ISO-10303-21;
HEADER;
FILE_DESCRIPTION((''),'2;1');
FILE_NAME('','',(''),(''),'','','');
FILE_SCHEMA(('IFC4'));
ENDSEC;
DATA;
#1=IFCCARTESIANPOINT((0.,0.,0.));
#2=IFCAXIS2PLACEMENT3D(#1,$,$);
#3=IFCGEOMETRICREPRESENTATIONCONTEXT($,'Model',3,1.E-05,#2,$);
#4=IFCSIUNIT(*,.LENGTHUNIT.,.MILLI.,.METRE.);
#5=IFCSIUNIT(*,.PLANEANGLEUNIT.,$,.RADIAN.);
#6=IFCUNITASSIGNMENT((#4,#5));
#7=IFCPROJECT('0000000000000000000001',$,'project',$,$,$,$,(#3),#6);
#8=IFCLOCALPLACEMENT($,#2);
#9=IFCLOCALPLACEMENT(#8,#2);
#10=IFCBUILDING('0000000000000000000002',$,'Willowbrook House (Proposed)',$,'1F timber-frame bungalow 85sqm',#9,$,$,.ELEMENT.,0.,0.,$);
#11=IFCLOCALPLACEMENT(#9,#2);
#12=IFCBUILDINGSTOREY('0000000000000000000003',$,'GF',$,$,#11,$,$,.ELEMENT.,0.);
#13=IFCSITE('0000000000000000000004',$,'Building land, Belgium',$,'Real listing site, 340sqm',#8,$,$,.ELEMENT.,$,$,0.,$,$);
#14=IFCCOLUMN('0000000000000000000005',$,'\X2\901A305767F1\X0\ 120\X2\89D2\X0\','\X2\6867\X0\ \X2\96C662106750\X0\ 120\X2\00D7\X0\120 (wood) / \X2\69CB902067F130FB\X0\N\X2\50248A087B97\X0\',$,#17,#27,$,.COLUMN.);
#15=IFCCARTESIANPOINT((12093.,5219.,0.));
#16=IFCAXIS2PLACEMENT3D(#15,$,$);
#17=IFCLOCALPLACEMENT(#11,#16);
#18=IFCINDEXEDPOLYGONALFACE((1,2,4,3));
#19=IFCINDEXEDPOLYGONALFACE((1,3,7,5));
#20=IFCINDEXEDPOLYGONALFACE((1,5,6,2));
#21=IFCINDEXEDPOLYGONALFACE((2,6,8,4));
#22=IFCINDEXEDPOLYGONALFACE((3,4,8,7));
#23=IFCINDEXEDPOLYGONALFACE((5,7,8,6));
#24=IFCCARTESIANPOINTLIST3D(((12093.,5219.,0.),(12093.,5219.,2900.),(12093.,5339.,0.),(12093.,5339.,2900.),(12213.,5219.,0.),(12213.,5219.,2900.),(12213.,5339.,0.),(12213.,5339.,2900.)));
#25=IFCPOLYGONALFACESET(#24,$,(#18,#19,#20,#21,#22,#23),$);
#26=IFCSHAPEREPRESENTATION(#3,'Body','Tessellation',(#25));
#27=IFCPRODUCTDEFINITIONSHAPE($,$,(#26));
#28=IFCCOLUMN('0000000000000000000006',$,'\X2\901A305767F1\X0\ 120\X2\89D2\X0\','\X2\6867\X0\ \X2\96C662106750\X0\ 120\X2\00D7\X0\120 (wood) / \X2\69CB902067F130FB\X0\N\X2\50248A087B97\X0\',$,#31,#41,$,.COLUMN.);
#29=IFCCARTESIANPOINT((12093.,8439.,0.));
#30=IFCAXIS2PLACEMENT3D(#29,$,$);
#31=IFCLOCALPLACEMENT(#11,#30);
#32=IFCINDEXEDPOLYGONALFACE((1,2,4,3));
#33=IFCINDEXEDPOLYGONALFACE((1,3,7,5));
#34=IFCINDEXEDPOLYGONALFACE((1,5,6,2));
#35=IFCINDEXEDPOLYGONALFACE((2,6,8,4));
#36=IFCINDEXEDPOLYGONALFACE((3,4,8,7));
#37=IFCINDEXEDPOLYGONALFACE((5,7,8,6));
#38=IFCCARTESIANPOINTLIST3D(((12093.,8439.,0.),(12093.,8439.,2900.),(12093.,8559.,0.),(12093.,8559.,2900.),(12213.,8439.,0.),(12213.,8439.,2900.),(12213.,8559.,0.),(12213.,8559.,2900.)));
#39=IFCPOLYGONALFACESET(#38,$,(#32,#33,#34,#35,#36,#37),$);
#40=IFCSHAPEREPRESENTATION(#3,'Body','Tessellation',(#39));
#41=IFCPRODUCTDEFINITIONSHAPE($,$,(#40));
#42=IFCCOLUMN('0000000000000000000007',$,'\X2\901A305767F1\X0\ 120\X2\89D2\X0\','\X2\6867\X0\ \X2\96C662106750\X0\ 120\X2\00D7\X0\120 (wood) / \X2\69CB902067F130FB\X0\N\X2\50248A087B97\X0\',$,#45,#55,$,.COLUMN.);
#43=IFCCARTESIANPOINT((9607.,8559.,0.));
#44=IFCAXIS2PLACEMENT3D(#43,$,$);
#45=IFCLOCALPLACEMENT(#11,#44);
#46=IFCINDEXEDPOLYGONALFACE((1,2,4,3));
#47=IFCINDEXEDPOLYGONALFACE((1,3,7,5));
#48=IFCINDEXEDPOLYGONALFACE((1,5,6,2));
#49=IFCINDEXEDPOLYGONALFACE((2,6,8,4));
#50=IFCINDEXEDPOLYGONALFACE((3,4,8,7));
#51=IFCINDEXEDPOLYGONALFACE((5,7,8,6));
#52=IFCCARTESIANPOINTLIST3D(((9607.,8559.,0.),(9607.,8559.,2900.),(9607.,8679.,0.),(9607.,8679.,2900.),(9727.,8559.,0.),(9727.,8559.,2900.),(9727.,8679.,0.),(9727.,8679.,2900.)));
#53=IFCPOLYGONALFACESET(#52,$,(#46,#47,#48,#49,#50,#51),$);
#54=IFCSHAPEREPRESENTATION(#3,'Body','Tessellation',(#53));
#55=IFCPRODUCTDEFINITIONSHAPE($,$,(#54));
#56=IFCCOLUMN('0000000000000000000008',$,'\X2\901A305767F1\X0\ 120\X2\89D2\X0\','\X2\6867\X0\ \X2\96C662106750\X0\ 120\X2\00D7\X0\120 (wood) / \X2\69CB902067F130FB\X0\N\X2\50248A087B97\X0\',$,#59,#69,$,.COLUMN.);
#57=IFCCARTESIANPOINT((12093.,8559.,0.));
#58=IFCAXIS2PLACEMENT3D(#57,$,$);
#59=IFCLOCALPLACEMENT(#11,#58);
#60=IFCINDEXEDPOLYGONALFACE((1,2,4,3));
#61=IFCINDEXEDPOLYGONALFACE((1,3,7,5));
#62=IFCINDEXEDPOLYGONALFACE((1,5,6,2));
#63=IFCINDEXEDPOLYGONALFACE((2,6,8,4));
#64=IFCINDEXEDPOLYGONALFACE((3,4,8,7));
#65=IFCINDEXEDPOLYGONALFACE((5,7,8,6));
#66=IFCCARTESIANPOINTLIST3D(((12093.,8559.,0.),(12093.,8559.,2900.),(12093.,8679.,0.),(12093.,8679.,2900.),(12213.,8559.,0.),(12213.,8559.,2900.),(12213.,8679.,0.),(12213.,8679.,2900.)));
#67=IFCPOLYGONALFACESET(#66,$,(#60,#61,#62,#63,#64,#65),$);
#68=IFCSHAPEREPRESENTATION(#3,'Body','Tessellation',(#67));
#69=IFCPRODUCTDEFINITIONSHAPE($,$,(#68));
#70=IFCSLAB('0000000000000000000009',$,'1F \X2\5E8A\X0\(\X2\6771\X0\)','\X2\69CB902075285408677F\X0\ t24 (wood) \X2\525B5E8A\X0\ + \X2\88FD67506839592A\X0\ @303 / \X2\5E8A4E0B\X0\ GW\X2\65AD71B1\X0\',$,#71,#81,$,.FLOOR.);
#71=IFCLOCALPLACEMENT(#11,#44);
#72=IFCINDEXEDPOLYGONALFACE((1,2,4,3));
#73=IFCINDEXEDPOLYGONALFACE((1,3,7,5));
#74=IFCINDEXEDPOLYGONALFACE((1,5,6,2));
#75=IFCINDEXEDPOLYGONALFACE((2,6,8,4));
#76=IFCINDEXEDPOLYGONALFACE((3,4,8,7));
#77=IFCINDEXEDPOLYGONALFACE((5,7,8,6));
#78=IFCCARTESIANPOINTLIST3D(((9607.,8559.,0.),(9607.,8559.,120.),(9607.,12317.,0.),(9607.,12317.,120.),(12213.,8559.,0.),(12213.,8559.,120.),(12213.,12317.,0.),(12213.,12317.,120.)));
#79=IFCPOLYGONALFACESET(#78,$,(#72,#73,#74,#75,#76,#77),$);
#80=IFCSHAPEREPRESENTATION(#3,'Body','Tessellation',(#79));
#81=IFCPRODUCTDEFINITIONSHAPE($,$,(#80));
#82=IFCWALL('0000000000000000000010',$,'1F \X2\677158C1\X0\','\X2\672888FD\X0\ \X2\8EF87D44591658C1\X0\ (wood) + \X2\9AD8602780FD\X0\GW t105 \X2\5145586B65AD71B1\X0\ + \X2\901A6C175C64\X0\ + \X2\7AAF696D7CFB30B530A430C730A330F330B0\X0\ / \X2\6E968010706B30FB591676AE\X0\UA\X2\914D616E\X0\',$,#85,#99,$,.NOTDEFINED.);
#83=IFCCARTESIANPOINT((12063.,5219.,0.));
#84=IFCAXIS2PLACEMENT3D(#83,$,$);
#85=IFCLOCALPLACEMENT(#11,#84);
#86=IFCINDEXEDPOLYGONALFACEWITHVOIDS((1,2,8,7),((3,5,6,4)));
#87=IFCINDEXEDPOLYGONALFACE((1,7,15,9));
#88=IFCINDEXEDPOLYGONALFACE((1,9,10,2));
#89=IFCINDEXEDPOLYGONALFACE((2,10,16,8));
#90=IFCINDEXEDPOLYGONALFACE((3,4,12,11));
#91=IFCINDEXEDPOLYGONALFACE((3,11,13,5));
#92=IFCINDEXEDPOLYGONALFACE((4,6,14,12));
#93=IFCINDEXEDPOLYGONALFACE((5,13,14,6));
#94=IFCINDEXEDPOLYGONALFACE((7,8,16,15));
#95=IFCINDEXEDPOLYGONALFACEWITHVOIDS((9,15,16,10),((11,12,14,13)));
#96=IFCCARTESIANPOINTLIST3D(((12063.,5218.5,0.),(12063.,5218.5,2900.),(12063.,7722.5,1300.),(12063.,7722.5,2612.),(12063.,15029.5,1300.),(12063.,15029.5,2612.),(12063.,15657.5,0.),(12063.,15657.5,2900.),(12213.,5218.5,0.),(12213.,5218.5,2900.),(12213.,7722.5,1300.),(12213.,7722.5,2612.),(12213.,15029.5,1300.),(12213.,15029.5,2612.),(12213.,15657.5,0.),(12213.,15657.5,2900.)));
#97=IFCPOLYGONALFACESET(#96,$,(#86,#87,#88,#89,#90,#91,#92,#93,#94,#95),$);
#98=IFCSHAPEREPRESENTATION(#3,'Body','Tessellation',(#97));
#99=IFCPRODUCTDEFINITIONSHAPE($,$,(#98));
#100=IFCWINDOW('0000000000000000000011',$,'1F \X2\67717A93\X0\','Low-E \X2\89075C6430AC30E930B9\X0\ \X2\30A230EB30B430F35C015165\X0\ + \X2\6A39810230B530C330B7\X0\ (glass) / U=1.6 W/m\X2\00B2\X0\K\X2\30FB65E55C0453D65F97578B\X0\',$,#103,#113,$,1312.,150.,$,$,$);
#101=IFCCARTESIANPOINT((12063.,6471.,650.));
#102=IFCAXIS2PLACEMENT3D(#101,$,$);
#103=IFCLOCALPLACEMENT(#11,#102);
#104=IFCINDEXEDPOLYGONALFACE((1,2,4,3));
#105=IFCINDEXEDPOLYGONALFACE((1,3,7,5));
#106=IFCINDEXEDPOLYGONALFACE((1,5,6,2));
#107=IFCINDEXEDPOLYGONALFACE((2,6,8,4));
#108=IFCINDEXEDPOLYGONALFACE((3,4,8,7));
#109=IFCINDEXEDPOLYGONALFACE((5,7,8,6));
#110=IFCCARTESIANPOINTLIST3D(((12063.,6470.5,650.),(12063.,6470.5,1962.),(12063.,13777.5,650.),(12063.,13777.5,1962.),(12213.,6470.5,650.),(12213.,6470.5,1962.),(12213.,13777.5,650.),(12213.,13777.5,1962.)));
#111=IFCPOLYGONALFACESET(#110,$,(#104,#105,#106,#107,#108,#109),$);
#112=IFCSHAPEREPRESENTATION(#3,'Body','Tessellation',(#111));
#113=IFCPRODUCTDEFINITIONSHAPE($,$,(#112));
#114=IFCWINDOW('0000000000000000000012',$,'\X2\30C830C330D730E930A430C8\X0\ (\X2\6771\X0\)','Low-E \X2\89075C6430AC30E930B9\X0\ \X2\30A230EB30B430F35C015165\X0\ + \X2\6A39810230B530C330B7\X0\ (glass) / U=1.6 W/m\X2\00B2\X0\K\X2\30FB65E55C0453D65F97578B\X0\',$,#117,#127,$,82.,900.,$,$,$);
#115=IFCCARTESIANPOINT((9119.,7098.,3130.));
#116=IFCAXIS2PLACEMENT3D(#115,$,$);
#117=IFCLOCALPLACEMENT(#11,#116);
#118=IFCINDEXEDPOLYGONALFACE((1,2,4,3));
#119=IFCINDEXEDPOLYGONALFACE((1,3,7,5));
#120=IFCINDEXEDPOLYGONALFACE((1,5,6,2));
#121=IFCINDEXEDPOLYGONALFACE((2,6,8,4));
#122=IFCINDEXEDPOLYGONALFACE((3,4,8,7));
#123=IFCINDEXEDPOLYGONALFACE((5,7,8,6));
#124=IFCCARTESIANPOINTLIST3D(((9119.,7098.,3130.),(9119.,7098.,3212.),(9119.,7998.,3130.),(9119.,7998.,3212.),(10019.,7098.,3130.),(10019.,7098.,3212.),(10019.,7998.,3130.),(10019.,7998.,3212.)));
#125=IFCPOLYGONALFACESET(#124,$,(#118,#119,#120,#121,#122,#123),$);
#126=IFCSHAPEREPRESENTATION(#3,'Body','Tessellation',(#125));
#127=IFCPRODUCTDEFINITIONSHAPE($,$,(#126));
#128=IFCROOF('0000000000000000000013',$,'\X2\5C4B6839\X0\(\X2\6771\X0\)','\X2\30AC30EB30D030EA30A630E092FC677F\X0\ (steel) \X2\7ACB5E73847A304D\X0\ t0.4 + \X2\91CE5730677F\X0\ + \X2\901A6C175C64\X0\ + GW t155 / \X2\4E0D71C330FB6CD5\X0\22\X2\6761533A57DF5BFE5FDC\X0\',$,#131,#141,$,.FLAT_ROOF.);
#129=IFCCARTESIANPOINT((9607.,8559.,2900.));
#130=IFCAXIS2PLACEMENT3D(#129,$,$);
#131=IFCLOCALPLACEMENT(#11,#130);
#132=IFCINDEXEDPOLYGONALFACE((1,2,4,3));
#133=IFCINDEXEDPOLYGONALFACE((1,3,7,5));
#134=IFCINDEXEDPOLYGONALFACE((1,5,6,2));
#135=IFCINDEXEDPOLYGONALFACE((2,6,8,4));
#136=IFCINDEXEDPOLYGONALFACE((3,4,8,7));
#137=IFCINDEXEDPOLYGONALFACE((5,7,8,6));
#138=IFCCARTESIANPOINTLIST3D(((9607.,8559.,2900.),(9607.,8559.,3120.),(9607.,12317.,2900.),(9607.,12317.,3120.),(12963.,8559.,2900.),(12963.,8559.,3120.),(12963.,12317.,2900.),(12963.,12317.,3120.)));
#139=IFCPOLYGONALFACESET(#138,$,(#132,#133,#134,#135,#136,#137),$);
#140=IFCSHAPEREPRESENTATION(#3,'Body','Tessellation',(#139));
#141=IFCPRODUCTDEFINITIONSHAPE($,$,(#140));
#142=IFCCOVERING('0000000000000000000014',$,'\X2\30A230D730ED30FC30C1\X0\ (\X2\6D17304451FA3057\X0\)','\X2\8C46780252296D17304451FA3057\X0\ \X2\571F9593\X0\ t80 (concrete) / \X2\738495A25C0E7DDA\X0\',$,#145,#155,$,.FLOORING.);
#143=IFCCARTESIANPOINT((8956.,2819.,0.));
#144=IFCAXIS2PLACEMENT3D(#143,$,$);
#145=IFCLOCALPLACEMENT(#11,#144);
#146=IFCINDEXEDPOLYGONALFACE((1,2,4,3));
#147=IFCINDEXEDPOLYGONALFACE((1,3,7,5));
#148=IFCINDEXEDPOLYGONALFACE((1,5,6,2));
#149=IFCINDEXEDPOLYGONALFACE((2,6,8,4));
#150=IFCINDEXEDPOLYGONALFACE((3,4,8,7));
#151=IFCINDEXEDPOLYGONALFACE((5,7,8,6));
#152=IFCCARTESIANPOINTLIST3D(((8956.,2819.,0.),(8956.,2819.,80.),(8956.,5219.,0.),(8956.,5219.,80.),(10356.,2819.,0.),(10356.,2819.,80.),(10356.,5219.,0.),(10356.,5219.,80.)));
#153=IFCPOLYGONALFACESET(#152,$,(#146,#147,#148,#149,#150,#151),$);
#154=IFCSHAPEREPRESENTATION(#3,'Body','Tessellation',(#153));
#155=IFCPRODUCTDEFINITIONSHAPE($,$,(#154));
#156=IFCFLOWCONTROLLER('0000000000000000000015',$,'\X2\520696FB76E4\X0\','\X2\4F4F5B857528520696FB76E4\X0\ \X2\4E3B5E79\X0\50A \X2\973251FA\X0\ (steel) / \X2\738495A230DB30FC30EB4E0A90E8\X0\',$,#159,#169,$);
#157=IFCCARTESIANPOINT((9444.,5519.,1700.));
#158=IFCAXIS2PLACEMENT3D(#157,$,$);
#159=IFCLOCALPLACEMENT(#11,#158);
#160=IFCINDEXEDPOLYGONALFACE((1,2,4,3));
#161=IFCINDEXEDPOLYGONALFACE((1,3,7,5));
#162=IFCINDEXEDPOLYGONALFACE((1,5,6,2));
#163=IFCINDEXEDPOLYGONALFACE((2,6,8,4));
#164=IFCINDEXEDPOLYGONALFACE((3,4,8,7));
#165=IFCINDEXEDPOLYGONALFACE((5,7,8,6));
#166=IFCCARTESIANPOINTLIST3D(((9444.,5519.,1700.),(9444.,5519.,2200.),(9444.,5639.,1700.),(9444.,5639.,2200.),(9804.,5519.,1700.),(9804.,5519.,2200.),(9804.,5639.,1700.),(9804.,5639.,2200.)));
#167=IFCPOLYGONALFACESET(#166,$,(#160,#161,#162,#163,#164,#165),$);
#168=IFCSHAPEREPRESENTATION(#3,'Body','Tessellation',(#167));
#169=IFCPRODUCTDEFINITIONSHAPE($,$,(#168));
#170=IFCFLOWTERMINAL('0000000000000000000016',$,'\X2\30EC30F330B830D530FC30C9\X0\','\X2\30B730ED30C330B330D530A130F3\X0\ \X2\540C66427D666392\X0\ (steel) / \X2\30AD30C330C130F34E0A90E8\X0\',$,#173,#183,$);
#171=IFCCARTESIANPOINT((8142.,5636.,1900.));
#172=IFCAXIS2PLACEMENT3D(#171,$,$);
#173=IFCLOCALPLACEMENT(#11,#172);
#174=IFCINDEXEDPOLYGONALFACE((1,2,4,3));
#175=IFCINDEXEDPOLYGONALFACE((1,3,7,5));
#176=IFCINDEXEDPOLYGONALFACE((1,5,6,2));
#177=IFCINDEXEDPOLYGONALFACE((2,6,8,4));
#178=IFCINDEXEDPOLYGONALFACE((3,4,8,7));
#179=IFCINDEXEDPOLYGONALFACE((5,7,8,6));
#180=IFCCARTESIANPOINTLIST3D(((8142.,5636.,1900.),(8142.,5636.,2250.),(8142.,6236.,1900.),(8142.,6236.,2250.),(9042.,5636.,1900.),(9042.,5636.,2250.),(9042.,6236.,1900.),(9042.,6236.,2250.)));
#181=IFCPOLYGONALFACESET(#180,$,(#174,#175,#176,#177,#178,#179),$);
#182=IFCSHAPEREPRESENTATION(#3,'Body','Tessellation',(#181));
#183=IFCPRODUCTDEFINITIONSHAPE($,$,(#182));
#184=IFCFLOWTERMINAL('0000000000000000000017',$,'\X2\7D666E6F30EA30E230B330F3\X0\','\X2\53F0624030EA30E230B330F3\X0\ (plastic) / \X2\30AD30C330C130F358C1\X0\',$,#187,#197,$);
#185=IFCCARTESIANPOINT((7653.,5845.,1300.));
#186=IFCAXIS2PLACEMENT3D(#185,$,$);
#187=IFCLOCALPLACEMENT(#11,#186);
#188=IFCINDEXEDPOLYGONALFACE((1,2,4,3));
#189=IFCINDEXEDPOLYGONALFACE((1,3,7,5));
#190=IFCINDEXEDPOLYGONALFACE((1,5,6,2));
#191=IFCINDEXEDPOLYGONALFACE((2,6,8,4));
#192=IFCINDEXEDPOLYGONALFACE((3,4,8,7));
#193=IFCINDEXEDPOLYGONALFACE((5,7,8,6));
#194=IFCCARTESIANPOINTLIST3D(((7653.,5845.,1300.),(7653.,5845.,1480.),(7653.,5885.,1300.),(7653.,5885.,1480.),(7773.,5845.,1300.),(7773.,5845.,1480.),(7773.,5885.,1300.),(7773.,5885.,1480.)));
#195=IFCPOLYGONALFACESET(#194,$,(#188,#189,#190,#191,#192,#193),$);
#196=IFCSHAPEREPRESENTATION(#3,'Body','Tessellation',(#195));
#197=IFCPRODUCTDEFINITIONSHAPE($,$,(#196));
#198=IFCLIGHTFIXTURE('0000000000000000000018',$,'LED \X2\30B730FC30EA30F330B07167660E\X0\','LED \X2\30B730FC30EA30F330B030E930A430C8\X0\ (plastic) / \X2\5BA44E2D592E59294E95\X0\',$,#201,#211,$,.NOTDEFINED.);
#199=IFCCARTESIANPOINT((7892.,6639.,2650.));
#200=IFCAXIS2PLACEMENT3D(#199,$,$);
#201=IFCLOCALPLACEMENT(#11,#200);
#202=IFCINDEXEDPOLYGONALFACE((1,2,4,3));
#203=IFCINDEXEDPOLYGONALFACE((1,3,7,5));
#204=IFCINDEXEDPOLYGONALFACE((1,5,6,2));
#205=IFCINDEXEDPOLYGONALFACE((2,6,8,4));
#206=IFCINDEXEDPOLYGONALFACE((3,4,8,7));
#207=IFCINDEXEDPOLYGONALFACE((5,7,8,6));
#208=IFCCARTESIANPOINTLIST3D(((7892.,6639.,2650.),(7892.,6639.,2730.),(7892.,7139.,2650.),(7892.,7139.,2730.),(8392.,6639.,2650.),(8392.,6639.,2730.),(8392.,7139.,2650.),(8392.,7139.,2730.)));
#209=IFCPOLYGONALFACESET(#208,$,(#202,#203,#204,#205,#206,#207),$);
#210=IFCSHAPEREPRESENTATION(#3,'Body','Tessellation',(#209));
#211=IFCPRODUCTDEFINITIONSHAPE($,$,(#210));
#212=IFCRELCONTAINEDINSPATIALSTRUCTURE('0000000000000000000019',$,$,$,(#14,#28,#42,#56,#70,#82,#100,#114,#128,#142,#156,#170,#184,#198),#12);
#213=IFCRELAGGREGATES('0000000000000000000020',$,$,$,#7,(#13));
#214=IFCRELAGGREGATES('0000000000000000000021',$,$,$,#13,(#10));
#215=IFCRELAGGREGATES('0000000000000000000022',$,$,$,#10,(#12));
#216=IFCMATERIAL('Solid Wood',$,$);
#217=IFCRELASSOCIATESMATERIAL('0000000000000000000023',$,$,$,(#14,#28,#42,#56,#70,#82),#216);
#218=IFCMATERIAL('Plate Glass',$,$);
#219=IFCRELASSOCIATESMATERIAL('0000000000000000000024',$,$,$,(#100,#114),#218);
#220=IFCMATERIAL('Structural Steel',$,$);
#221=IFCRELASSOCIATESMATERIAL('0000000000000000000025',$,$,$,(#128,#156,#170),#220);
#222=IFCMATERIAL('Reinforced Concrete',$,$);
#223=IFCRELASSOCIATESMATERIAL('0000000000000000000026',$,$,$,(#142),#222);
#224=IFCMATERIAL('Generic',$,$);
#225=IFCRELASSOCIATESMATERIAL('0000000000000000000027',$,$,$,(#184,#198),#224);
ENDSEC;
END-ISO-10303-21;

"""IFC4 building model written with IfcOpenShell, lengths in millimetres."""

from ifc_helpers import new_model, si_unit, frame, frame_2d, origin, place, context, project, spatial, rectangle, extrude, material, element, fill, save


model = new_model("IFC4")

# Units and contexts
model_context = context("Model", 3, precision=1e-05, world=origin())
ifc_project = project(units=[si_unit("LENGTHUNIT", "METRE", prefix="MILLI"), si_unit("PLANEANGLEUNIT", "RADIAN")], contexts=[model_context])

# Site, building, storey
site_placement = place(None, origin())
site = spatial("IfcSite", under=ifc_project, at=site_placement, Name="Building land, Belgium", ObjectType="Real listing site, 340sqm", CompositionType="ELEMENT", RefElevation=0.0)
building_placement = place(site_placement, origin())
building = spatial("IfcBuilding", under=site, at=building_placement, Name="Willowbrook House (Proposed)", ObjectType="1F timber-frame bungalow 85sqm", CompositionType="ELEMENT", ElevationOfRefHeight=0.0, ElevationOfTerrain=0.0)
storey_placement = place(building_placement, origin())
storey = spatial("IfcBuildingStorey", under=building, at=storey_placement, Name="GF", CompositionType="ELEMENT", Elevation=0.0)

# Columns
ifc_material_1 = material(Name="Solid Wood")
column_1_placement = place(storey_placement, frame((12093.0, 5219.0, 0.0)))
element("IfcColumn", 1, at=column_1_placement, inside=storey, material=ifc_material_1, Name="通し柱 120角", Description="桧 集成材 120×120 (wood) / 構造柱・N値計算", PredefinedType="COLUMN", context=model_context, shape_type="SweptSolid", body=[
    extrude(rectangle(XDim=120.0, YDim=120.0, at=frame_2d((60.0, 60.0))), frame((12093.0, 5219.0, 0.0)), (0.0, 0.0, 1.0), 2900.0),
])
column_2_placement = place(storey_placement, frame((12093.0, 8439.0, 0.0)))
element("IfcColumn", 2, at=column_2_placement, inside=storey, material=ifc_material_1, Name="通し柱 120角", Description="桧 集成材 120×120 (wood) / 構造柱・N値計算", PredefinedType="COLUMN", context=model_context, shape_type="SweptSolid", body=[
    extrude(rectangle(XDim=120.0, YDim=120.0, at=frame_2d((60.0, 60.0))), frame((12093.0, 8439.0, 0.0)), (0.0, 0.0, 1.0), 2900.0),
])
column_3_placement = place(storey_placement, frame((9607.0, 8559.0, 0.0)))
element("IfcColumn", 3, at=column_3_placement, inside=storey, material=ifc_material_1, Name="通し柱 120角", Description="桧 集成材 120×120 (wood) / 構造柱・N値計算", PredefinedType="COLUMN", context=model_context, shape_type="SweptSolid", body=[
    extrude(rectangle(XDim=120.0, YDim=120.0, at=frame_2d((60.0, 60.0))), frame((9607.0, 8559.0, 0.0)), (0.0, 0.0, 1.0), 2900.0),
])
column_4_placement = place(storey_placement, frame((12093.0, 8559.0, 0.0)))
element("IfcColumn", 4, at=column_4_placement, inside=storey, material=ifc_material_1, Name="通し柱 120角", Description="桧 集成材 120×120 (wood) / 構造柱・N値計算", PredefinedType="COLUMN", context=model_context, shape_type="SweptSolid", body=[
    extrude(rectangle(XDim=120.0, YDim=120.0, at=frame_2d((60.0, 60.0))), frame((12093.0, 8559.0, 0.0)), (0.0, 0.0, 1.0), 2900.0),
])

# Slab
slab_placement = place(storey_placement, frame((9607.0, 8559.0, 0.0)))
element("IfcSlab", 5, at=slab_placement, inside=storey, material=ifc_material_1, Name="1F 床(東)", Description="構造用合板 t24 (wood) 剛床 + 製材根太 @303 / 床下 GW断熱", PredefinedType="FLOOR", context=model_context, shape_type="SweptSolid", body=[
    extrude(rectangle(XDim=2606.0, YDim=3758.0, at=frame_2d((1303.0, 1879.0))), frame((9607.0, 8559.0, 0.0)), (0.0, 0.0, 1.0), 120.0),
])

# Wall, opening, window
wall_1_placement = place(storey_placement, frame((12063.0, 5219.0, 0.0)))
wall_1 = element("IfcWall", 6, at=wall_1_placement, inside=storey, material=ifc_material_1, Name="1F 東壁", Description="木製 軸組外壁 (wood) + 高性能GW t105 充填断熱 + 通気層 + 窯業系サイディング / 準耐火・外皮UA配慮", PredefinedType="NOTDEFINED", context=model_context, shape_type="SweptSolid", body=[
    extrude(rectangle(XDim=150.0, YDim=10439.0, at=frame_2d((75.0, 5219.0))), frame((12063.0, 5219.0, 0.0)), (0.0, 0.0, 1.0), 2900.0),
])
opening_placement = place(storey_placement, frame((12063.0, 6471.0, 650.0)))
opening = element("IfcOpeningElement", 7, at=opening_placement, cuts=wall_1, PredefinedType="NOTDEFINED", context=model_context, shape_type="SweptSolid", body=[
    extrude(rectangle(XDim=150.0, YDim=7307.0, at=frame_2d((75.0, 3653.0))), frame((12063.0, 6471.0, 650.0)), (0.0, 0.0, 1.0), 1312.0),
])
ifc_material_2 = material(Name="Plate Glass")
window_1_placement = place(storey_placement, frame((12063.0, 6471.0, 650.0)))
window_1 = element("IfcWindow", 8, at=window_1_placement, inside=storey, material=ifc_material_2, Name="1F 東窓", Description="Low-E 複層ガラス アルゴン封入 + 樹脂サッシ (glass) / U=1.6 W/m²K・日射取得型", OverallHeight=1312.0, OverallWidth=150.0, context=model_context, shape_type="SweptSolid", body=[
    extrude(rectangle(XDim=150.0, YDim=7307.0, at=frame_2d((75.0, 3653.0))), frame((12063.0, 6471.0, 650.0)), (0.0, 0.0, 1.0), 1312.0),
])
fill(opening, window_1)

# Window
window_2_placement = place(storey_placement, frame((9119.0, 7098.0, 3130.0)))
element("IfcWindow", 9, at=window_2_placement, inside=storey, material=ifc_material_2, Name="トップライト (東)", Description="Low-E 複層ガラス アルゴン封入 + 樹脂サッシ (glass) / U=1.6 W/m²K・日射取得型", OverallHeight=82.0, OverallWidth=900.0, context=model_context, shape_type="SweptSolid", body=[
    extrude(rectangle(XDim=900.0, YDim=900.0, at=frame_2d((450.0, 450.0))), frame((9119.0, 7098.0, 3130.0)), (0.0, 0.0, 1.0), 82.0),
])

# Roof
ifc_material_3 = material(Name="Structural Steel")
roof_placement = place(storey_placement, frame((9607.0, 8559.0, 2900.0)))
element("IfcRoof", 10, at=roof_placement, inside=storey, material=ifc_material_3, Name="屋根(東)", Description="ガルバリウム鋼板 (steel) 立平葺き t0.4 + 野地板 + 通気層 + GW t155 / 不燃・法22条区域対応", PredefinedType="FLAT_ROOF", context=model_context, shape_type="SweptSolid", body=[
    extrude(rectangle(XDim=3356.0, YDim=3758.0, at=frame_2d((1678.0, 1879.0))), frame((9607.0, 8559.0, 2900.0)), (0.0, 0.0, 1.0), 220.0),
])

# Covering
ifc_material_4 = material(Name="Reinforced Concrete")
covering_placement = place(storey_placement, frame((8956.0, 2819.0, 0.0)))
element("IfcCovering", 11, at=covering_placement, inside=storey, material=ifc_material_4, Name="アプローチ (洗い出し)", Description="豆砂利洗い出し 土間 t80 (concrete) / 玄関導線", PredefinedType="FLOORING", context=model_context, shape_type="SweptSolid", body=[
    extrude(rectangle(XDim=1400.0, YDim=2400.0, at=frame_2d((700.0, 1200.0))), frame((8956.0, 2819.0, 0.0)), (0.0, 0.0, 1.0), 80.0),
])

# Flow controller
flow_controller_placement = place(storey_placement, frame((9444.0, 5519.0, 1700.0)))
element("IfcFlowController", 12, at=flow_controller_placement, inside=storey, material=ifc_material_3, Name="分電盤", Description="住宅用分電盤 主幹50A 露出 (steel) / 玄関ホール上部", context=model_context, shape_type="SweptSolid", body=[
    extrude(rectangle(XDim=360.0, YDim=120.0, at=frame_2d((180.0, 60.0))), frame((9444.0, 5519.0, 1700.0)), (0.0, 0.0, 1.0), 500.0),
])

# Flow terminals
flow_terminal_1_placement = place(storey_placement, frame((8142.0, 5636.0, 1900.0)))
element("IfcFlowTerminal", 13, at=flow_terminal_1_placement, inside=storey, material=ifc_material_3, Name="レンジフード", Description="シロッコファン 同時給排 (steel) / キッチン上部", context=model_context, shape_type="SweptSolid", body=[
    extrude(rectangle(XDim=900.0, YDim=600.0, at=frame_2d((450.0, 300.0))), frame((8142.0, 5636.0, 1900.0)), (0.0, 0.0, 1.0), 350.0),
])
ifc_material_5 = material(Name="Generic")
flow_terminal_2_placement = place(storey_placement, frame((7653.0, 5845.0, 1300.0)))
element("IfcFlowTerminal", 14, at=flow_terminal_2_placement, inside=storey, material=ifc_material_5, Name="給湯リモコン", Description="台所リモコン (plastic) / キッチン壁", context=model_context, shape_type="SweptSolid", body=[
    extrude(rectangle(XDim=120.0, YDim=40.0, at=frame_2d((60.0, 20.0))), frame((7653.0, 5845.0, 1300.0)), (0.0, 0.0, 1.0), 180.0),
])

# Light fixture
light_fixture_placement = place(storey_placement, frame((7892.0, 6639.0, 2650.0)))
element("IfcLightFixture", 15, at=light_fixture_placement, inside=storey, material=ifc_material_5, Name="LED シーリング照明", Description="LED シーリングライト (plastic) / 室中央天井", PredefinedType="NOTDEFINED", context=model_context, shape_type="SweptSolid", body=[
    extrude(rectangle(XDim=500.0, YDim=500.0, at=frame_2d((250.0, 250.0))), frame((7892.0, 6639.0, 2650.0)), (0.0, 0.0, 1.0), 80.0),
])

save(model, "model.ifc")
